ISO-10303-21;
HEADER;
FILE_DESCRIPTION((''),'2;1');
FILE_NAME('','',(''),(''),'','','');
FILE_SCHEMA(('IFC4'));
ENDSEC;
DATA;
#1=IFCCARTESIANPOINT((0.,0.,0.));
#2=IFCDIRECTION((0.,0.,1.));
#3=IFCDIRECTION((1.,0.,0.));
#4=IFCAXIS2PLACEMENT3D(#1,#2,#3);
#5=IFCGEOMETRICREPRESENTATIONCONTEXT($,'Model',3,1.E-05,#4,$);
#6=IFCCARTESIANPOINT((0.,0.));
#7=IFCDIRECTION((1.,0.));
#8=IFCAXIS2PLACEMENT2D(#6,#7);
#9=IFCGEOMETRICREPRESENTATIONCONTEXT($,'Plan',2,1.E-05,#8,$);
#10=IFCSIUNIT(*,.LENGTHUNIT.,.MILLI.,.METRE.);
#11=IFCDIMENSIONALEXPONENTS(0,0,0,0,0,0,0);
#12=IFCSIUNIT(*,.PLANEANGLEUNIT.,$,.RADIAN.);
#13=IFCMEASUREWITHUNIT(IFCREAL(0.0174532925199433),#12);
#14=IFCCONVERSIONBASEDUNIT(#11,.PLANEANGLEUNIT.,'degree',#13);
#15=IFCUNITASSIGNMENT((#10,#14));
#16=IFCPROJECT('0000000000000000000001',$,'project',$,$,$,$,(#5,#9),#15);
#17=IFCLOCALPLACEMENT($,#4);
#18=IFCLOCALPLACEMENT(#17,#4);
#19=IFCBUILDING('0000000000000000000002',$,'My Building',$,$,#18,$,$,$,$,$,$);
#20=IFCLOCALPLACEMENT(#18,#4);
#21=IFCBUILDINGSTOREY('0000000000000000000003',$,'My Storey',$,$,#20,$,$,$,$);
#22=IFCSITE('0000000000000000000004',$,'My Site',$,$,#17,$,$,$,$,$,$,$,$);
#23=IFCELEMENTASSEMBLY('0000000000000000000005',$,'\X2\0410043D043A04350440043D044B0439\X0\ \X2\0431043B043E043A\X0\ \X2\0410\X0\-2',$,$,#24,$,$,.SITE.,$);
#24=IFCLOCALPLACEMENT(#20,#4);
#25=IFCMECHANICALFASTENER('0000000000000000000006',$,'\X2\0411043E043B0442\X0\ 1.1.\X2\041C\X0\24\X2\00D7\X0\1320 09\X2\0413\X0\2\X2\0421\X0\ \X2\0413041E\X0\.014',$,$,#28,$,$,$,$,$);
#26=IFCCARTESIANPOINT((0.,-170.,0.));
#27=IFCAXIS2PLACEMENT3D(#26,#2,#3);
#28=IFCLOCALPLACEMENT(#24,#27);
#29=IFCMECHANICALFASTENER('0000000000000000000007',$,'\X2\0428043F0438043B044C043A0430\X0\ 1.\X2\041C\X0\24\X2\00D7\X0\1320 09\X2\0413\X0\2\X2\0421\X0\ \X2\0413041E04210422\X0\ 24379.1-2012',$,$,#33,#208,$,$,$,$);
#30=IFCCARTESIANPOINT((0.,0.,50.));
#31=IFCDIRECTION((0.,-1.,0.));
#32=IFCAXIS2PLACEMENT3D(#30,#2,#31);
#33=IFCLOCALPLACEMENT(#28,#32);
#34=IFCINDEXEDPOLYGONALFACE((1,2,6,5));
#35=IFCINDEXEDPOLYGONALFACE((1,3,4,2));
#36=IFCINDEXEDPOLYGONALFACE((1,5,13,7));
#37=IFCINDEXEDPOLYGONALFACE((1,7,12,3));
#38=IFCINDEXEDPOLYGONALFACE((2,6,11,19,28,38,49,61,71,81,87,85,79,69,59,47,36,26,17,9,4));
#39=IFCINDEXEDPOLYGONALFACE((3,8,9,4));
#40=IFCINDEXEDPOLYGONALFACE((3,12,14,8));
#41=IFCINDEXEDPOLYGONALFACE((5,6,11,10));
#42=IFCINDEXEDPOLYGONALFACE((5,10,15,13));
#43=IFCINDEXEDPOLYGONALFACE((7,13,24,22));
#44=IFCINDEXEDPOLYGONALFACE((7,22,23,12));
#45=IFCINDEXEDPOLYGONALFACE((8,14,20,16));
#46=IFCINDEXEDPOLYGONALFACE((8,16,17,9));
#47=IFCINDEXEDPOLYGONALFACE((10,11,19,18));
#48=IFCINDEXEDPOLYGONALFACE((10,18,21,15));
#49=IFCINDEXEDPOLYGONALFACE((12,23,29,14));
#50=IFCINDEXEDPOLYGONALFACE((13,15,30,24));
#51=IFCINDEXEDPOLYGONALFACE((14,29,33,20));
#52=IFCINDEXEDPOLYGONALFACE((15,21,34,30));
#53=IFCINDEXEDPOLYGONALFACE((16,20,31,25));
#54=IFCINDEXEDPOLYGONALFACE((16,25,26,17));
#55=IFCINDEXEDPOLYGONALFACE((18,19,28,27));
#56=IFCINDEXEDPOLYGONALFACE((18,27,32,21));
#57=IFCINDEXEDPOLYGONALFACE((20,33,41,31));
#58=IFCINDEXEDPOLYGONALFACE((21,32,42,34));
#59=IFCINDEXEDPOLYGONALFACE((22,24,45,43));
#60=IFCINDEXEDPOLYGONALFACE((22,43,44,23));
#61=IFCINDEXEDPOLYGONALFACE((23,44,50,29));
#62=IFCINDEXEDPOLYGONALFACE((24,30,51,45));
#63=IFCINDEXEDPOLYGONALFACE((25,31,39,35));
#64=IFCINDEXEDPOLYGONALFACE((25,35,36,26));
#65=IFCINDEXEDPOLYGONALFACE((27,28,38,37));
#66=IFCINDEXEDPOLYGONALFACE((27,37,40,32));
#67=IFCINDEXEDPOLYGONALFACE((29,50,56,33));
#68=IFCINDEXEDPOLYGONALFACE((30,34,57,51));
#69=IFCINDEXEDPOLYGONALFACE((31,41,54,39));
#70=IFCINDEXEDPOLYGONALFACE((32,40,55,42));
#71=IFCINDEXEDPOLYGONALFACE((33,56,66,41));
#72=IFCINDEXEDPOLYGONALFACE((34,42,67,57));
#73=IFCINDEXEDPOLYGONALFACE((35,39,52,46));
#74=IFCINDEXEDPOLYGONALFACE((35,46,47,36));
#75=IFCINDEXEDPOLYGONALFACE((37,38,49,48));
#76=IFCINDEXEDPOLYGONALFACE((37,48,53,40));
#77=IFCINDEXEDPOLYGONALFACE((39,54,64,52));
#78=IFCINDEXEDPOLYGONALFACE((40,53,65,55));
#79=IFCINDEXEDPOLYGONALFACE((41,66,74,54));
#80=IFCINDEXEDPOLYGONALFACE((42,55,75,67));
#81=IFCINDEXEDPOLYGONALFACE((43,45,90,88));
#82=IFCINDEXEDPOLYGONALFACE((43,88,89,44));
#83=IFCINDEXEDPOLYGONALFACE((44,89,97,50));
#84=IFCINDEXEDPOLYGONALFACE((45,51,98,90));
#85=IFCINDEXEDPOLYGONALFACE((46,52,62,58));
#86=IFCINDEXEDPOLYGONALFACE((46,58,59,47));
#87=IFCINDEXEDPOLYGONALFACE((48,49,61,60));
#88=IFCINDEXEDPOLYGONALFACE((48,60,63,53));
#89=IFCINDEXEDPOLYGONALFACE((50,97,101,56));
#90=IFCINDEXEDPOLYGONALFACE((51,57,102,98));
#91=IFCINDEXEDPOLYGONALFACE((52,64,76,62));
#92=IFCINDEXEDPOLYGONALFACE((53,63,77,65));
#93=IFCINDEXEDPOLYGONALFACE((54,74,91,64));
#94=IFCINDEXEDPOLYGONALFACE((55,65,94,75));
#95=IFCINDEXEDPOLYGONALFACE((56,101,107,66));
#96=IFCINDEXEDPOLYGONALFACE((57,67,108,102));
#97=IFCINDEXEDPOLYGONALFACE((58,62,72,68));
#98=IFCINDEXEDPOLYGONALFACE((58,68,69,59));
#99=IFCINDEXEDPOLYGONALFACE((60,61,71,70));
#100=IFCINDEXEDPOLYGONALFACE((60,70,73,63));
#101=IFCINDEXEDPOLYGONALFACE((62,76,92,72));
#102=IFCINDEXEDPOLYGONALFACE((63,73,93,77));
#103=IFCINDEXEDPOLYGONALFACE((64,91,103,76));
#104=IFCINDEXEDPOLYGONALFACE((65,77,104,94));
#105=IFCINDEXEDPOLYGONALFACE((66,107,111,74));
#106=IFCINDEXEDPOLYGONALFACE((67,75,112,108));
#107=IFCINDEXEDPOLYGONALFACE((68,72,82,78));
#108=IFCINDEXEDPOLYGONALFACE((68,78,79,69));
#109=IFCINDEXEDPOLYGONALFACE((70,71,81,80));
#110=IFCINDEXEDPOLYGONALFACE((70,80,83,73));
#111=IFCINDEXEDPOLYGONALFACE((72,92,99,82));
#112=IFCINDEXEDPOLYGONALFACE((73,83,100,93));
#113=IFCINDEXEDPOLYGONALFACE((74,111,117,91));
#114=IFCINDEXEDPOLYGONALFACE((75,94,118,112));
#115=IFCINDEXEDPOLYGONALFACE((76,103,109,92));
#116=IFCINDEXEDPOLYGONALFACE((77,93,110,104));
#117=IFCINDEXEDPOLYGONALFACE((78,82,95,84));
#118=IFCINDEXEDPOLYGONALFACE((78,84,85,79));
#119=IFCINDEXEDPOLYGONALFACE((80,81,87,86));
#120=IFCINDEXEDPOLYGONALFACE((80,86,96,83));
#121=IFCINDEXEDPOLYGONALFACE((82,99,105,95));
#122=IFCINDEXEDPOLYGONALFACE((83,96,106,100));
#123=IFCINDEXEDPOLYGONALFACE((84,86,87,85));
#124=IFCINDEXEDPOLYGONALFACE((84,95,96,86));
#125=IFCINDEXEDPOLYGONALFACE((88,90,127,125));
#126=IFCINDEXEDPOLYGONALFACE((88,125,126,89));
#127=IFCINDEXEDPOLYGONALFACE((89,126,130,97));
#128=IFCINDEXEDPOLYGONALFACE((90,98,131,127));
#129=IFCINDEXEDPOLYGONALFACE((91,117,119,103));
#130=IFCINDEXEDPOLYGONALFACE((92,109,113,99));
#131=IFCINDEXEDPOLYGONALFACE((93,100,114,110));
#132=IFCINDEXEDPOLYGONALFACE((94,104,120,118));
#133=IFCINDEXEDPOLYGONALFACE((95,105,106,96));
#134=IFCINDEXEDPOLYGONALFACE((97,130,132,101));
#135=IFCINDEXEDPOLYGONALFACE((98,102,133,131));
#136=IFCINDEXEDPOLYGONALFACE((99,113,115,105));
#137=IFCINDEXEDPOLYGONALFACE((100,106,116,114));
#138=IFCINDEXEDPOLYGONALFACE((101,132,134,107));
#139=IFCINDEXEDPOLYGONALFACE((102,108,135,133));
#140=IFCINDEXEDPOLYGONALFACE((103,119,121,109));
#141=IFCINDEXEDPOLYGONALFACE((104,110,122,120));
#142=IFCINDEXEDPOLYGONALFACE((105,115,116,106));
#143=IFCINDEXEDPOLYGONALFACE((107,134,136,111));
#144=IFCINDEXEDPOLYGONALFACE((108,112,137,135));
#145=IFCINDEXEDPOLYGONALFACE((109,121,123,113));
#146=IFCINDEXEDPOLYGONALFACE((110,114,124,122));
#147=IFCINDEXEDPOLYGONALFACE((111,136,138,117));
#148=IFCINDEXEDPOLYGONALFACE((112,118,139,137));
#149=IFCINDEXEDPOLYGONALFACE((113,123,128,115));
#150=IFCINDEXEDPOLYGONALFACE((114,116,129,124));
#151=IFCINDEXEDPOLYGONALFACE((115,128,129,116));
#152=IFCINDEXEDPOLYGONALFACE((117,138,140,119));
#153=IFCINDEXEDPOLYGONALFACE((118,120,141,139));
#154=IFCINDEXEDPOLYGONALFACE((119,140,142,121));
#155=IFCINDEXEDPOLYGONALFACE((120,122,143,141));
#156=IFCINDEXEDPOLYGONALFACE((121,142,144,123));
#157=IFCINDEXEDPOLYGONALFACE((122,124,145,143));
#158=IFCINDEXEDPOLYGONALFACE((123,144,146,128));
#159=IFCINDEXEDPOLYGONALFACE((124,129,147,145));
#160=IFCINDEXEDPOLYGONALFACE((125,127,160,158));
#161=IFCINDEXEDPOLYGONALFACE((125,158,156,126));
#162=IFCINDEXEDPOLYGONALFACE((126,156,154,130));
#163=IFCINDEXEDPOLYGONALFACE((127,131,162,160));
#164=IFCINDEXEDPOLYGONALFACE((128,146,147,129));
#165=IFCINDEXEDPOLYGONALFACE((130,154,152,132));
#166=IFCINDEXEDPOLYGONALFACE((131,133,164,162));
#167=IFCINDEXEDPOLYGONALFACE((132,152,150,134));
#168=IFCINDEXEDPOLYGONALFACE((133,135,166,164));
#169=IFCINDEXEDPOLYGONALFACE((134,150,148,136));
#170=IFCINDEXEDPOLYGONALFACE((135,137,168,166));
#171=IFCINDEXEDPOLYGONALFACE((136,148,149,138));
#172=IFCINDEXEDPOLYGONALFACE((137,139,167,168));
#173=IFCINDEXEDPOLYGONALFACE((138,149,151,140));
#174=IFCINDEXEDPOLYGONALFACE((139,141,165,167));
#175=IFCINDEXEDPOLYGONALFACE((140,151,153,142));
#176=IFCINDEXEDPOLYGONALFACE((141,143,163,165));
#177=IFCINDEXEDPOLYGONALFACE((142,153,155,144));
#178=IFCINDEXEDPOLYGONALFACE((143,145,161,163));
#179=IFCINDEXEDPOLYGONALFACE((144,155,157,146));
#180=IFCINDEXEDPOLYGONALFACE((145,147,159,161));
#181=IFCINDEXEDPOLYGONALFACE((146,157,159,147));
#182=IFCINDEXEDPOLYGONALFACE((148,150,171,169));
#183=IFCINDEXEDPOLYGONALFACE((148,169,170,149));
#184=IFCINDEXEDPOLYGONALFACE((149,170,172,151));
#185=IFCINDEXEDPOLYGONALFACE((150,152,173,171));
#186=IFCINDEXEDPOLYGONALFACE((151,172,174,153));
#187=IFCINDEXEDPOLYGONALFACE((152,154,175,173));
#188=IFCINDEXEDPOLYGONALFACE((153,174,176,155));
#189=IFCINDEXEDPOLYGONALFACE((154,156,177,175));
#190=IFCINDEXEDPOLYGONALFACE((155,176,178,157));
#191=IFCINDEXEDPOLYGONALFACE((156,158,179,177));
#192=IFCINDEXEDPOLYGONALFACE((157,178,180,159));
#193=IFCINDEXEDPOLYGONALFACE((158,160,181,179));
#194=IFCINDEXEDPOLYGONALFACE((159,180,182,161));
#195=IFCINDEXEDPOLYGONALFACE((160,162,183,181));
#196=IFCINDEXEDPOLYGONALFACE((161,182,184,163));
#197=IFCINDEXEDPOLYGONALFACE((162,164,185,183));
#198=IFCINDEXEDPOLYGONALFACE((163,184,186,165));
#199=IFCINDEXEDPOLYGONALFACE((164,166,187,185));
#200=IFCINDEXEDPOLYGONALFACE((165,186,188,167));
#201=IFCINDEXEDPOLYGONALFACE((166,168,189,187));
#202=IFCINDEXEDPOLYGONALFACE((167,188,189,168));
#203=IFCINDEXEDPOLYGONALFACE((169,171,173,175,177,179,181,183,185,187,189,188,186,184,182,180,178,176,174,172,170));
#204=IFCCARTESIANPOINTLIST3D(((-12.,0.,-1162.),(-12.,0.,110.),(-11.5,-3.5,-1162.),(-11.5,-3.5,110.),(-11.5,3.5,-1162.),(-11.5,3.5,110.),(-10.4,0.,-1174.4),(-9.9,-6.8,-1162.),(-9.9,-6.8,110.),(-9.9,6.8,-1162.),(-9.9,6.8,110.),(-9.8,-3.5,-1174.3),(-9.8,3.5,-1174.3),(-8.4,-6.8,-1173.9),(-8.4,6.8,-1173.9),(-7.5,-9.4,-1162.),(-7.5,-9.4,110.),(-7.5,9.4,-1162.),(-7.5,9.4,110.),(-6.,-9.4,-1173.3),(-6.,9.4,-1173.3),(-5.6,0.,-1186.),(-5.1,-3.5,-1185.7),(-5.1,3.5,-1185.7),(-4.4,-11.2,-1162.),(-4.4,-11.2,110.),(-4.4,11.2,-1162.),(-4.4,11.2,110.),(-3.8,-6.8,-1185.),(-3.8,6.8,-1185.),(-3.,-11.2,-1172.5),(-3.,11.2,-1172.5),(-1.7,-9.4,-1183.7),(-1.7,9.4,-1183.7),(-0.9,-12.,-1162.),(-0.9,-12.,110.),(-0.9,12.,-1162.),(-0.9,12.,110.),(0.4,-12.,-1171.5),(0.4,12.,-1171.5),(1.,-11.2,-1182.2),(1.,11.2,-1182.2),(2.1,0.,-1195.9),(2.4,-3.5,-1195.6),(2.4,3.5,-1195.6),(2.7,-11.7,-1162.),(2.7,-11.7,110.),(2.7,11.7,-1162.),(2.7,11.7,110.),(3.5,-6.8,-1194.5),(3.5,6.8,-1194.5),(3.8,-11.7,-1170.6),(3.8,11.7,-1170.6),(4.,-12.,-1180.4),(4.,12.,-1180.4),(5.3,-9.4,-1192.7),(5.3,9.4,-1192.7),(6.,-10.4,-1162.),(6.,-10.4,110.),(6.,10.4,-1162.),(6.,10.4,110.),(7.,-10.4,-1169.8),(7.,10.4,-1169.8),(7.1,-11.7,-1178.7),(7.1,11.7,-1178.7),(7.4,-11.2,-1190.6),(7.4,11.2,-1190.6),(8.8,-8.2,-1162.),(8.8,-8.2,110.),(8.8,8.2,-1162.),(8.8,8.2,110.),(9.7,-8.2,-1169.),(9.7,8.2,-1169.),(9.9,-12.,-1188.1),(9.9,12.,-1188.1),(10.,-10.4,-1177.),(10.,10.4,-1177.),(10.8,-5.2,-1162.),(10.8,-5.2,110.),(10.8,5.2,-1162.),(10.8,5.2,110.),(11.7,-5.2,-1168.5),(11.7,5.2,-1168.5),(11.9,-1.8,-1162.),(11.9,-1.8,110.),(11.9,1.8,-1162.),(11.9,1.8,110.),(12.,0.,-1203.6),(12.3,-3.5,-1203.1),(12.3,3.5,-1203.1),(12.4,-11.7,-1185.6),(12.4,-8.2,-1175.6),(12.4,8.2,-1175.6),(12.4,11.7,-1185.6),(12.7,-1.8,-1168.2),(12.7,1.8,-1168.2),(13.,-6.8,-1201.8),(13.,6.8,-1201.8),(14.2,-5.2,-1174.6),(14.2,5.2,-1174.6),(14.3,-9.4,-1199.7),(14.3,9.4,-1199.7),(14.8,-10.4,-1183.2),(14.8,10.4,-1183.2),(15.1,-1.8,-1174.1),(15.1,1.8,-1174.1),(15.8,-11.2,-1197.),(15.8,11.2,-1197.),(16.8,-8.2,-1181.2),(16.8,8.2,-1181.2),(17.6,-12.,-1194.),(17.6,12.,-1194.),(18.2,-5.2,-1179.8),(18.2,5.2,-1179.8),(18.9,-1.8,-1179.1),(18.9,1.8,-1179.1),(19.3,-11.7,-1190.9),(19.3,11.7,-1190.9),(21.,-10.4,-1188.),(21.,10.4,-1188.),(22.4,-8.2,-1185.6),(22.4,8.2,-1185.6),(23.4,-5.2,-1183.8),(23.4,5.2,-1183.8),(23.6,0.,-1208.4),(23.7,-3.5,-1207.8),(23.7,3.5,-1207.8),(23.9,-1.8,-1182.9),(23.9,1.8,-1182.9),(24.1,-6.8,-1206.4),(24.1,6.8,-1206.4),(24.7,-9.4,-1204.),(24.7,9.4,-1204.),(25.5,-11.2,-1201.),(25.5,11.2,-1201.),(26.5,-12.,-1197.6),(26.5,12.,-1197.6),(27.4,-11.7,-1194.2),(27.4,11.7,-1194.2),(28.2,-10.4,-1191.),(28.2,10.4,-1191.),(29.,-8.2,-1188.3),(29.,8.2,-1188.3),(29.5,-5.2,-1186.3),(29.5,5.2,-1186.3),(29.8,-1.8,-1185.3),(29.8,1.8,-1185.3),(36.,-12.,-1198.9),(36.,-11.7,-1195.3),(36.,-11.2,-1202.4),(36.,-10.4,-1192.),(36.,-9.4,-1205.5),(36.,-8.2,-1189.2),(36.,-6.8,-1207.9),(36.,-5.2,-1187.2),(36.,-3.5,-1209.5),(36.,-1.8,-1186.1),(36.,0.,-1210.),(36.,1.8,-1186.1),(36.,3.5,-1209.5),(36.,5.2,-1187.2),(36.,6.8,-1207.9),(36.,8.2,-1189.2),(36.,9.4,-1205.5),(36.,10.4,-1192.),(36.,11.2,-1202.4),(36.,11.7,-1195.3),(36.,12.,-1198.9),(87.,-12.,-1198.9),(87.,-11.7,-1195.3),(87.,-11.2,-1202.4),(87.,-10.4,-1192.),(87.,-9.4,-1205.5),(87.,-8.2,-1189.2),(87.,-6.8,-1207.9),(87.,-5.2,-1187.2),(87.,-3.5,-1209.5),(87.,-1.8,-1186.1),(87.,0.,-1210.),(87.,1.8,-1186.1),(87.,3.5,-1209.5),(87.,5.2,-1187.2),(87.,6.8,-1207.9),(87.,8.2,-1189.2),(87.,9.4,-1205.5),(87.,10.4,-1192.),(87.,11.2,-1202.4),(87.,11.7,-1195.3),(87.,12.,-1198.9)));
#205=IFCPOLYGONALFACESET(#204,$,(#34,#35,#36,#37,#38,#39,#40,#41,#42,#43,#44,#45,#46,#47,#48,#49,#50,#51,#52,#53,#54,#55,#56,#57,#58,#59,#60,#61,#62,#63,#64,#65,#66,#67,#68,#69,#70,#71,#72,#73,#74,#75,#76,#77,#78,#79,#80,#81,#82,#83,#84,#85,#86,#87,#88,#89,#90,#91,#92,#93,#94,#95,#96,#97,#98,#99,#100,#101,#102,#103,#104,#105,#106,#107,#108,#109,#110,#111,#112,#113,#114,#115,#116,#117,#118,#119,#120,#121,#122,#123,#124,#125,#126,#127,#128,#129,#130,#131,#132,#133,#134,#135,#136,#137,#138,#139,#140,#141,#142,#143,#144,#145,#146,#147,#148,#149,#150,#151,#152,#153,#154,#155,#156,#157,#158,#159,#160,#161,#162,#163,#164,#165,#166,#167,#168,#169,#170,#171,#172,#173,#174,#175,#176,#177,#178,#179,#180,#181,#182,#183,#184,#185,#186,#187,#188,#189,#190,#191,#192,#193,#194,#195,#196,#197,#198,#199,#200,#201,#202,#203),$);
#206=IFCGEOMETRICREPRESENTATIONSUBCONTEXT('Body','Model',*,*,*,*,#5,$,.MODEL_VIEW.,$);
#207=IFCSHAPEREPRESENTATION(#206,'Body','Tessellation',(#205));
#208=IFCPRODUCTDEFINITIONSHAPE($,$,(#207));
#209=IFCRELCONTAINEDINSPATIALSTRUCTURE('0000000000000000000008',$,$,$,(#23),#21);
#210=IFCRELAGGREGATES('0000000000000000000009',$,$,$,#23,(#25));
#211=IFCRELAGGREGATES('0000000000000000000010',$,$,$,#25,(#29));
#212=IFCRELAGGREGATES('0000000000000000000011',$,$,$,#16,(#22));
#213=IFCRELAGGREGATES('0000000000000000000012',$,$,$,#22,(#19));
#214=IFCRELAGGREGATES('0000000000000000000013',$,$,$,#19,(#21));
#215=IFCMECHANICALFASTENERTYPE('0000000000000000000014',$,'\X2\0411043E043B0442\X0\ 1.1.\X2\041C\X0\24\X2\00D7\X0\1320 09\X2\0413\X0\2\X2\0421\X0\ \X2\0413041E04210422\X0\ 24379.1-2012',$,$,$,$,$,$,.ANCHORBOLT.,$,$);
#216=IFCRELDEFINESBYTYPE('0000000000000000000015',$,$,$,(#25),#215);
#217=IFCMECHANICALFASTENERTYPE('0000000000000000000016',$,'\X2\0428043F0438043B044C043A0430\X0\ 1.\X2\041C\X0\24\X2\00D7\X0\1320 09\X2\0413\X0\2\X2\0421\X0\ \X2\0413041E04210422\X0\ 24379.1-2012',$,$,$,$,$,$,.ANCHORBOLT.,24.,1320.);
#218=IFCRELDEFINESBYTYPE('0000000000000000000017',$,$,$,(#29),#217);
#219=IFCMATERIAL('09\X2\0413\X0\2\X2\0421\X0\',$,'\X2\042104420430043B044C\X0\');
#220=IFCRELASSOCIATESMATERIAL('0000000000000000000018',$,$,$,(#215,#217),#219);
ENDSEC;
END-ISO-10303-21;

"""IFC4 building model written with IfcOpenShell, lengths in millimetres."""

from ifc_helpers import new_model, entity, si_unit, converted_unit, frame, origin_with_axes, origin_2d_with_axis, place, context, subcontext, project, spatial, source, transform, mapped, material, type_object, type_shapes, element, aggregate, save


model = new_model("IFC4")

# Units and contexts
model_context = context("Model", 3, precision=1e-05, world=origin_with_axes())
plan_context = context("Plan", 2, precision=1e-05, world=origin_2d_with_axis())
body_context = subcontext(model_context, "Body", "Model", "MODEL_VIEW")
ifc_project = project(units=[si_unit("LENGTHUNIT", "METRE", prefix="MILLI"), converted_unit("PLANEANGLEUNIT", "degree", entity("IfcReal", 0.0174532925199433), si_unit("PLANEANGLEUNIT", "RADIAN"), dimensions=[0, 0, 0, 0, 0, 0, 0])], contexts=[model_context, plan_context])

# Site, building, storey
site_placement = place(None, origin_with_axes())
site = spatial("IfcSite", under=ifc_project, at=site_placement, Name="My Site")
building_placement = place(site_placement, origin_with_axes())
building = spatial("IfcBuilding", under=site, at=building_placement, Name="My Building")
storey_placement = place(building_placement, origin_with_axes())
storey = spatial("IfcBuildingStorey", under=building, at=storey_placement, Name="My Storey")

# Element assembly
placement_1 = place(storey_placement, origin_with_axes())
assembly_1 = element("IfcElementAssembly", 1, at=placement_1, inside=storey, Name="Анкерный блок А-2", AssemblyPlace="SITE")

# Mechanical fasteners
ifc_material_1 = material(Name="09Г2С", Category="Сталь")
mechanical_fastener_type_1 = type_object("IfcMechanicalFastenerType", Name="Болт 1.1.М24×1320 09Г2С ГОСТ 24379.1-2012", PredefinedType="ANCHORBOLT", material=ifc_material_1)
mechanical_fastener_1_placement = place(placement_1, frame((0.0, -170.0, 0.0), z_axis=(0.0, 0.0, 1.0), x_axis=(1.0, 0.0, 0.0)))
mechanical_fastener_1 = element("IfcMechanicalFastener", 2, at=mechanical_fastener_1_placement, type_object=mechanical_fastener_type_1, Name="Болт 1.1.М24×1320 09Г2С ГО.014")
mechanical_fastener_type_2 = type_object("IfcMechanicalFastenerType", Name="Шпилька 1.М24×1320 09Г2С ГОСТ 24379.1-2012", NominalDiameter=24.0, NominalLength=1320.0, PredefinedType="ANCHORBOLT", material=ifc_material_1)
shared_shape_1 = source(frame((0.0, 0.0, 110.0), z_axis=(0.0, 0.0, 1.0), x_axis=(1.0, 0.0, 0.0)), body_context, "Body", "AdvancedSweptSolid", [
    entity("IfcSweptDiskSolid", entity("IfcIndexedPolyCurve", entity("IfcCartesianPointList3D", [[0.0, 0.0, 0.0], [0.0, 0.0, -1272.0], [10.5, 0.0, -1297.5], [36.0, 0.0, -1308.0], [87.0, 0.0, -1308.0]]), [entity("IfcLineIndex", [1, 2]), entity("IfcArcIndex", [2, 3, 4]), entity("IfcLineIndex", [4, 5])]), 12.0),
])
type_shapes(mechanical_fastener_type_2, [shared_shape_1])
mechanical_fastener_2_placement = place(mechanical_fastener_1_placement, frame((0.0, 0.0, 50.0), z_axis=(0.0, 0.0, 1.0), x_axis=(0.0, -1.0, 0.0)))
mechanical_fastener_2 = element("IfcMechanicalFastener", 3, at=mechanical_fastener_2_placement, type_object=mechanical_fastener_type_2, Name="Шпилька 1.М24×1320 09Г2С ГОСТ 24379.1-2012", context=body_context, shape_type="MappedRepresentation", body=[
    mapped(shared_shape_1, transform((0.0, 0.0, 0.0), x_axis=(1.0, 0.0, 0.0), y_axis=(0.0, 1.0, 0.0), z_axis=(0.0, 0.0, 1.0), scale=1.0)),
])

aggregate(assembly_1, [mechanical_fastener_1])

aggregate(mechanical_fastener_1, [mechanical_fastener_2])

save(model, "model.ifc")
